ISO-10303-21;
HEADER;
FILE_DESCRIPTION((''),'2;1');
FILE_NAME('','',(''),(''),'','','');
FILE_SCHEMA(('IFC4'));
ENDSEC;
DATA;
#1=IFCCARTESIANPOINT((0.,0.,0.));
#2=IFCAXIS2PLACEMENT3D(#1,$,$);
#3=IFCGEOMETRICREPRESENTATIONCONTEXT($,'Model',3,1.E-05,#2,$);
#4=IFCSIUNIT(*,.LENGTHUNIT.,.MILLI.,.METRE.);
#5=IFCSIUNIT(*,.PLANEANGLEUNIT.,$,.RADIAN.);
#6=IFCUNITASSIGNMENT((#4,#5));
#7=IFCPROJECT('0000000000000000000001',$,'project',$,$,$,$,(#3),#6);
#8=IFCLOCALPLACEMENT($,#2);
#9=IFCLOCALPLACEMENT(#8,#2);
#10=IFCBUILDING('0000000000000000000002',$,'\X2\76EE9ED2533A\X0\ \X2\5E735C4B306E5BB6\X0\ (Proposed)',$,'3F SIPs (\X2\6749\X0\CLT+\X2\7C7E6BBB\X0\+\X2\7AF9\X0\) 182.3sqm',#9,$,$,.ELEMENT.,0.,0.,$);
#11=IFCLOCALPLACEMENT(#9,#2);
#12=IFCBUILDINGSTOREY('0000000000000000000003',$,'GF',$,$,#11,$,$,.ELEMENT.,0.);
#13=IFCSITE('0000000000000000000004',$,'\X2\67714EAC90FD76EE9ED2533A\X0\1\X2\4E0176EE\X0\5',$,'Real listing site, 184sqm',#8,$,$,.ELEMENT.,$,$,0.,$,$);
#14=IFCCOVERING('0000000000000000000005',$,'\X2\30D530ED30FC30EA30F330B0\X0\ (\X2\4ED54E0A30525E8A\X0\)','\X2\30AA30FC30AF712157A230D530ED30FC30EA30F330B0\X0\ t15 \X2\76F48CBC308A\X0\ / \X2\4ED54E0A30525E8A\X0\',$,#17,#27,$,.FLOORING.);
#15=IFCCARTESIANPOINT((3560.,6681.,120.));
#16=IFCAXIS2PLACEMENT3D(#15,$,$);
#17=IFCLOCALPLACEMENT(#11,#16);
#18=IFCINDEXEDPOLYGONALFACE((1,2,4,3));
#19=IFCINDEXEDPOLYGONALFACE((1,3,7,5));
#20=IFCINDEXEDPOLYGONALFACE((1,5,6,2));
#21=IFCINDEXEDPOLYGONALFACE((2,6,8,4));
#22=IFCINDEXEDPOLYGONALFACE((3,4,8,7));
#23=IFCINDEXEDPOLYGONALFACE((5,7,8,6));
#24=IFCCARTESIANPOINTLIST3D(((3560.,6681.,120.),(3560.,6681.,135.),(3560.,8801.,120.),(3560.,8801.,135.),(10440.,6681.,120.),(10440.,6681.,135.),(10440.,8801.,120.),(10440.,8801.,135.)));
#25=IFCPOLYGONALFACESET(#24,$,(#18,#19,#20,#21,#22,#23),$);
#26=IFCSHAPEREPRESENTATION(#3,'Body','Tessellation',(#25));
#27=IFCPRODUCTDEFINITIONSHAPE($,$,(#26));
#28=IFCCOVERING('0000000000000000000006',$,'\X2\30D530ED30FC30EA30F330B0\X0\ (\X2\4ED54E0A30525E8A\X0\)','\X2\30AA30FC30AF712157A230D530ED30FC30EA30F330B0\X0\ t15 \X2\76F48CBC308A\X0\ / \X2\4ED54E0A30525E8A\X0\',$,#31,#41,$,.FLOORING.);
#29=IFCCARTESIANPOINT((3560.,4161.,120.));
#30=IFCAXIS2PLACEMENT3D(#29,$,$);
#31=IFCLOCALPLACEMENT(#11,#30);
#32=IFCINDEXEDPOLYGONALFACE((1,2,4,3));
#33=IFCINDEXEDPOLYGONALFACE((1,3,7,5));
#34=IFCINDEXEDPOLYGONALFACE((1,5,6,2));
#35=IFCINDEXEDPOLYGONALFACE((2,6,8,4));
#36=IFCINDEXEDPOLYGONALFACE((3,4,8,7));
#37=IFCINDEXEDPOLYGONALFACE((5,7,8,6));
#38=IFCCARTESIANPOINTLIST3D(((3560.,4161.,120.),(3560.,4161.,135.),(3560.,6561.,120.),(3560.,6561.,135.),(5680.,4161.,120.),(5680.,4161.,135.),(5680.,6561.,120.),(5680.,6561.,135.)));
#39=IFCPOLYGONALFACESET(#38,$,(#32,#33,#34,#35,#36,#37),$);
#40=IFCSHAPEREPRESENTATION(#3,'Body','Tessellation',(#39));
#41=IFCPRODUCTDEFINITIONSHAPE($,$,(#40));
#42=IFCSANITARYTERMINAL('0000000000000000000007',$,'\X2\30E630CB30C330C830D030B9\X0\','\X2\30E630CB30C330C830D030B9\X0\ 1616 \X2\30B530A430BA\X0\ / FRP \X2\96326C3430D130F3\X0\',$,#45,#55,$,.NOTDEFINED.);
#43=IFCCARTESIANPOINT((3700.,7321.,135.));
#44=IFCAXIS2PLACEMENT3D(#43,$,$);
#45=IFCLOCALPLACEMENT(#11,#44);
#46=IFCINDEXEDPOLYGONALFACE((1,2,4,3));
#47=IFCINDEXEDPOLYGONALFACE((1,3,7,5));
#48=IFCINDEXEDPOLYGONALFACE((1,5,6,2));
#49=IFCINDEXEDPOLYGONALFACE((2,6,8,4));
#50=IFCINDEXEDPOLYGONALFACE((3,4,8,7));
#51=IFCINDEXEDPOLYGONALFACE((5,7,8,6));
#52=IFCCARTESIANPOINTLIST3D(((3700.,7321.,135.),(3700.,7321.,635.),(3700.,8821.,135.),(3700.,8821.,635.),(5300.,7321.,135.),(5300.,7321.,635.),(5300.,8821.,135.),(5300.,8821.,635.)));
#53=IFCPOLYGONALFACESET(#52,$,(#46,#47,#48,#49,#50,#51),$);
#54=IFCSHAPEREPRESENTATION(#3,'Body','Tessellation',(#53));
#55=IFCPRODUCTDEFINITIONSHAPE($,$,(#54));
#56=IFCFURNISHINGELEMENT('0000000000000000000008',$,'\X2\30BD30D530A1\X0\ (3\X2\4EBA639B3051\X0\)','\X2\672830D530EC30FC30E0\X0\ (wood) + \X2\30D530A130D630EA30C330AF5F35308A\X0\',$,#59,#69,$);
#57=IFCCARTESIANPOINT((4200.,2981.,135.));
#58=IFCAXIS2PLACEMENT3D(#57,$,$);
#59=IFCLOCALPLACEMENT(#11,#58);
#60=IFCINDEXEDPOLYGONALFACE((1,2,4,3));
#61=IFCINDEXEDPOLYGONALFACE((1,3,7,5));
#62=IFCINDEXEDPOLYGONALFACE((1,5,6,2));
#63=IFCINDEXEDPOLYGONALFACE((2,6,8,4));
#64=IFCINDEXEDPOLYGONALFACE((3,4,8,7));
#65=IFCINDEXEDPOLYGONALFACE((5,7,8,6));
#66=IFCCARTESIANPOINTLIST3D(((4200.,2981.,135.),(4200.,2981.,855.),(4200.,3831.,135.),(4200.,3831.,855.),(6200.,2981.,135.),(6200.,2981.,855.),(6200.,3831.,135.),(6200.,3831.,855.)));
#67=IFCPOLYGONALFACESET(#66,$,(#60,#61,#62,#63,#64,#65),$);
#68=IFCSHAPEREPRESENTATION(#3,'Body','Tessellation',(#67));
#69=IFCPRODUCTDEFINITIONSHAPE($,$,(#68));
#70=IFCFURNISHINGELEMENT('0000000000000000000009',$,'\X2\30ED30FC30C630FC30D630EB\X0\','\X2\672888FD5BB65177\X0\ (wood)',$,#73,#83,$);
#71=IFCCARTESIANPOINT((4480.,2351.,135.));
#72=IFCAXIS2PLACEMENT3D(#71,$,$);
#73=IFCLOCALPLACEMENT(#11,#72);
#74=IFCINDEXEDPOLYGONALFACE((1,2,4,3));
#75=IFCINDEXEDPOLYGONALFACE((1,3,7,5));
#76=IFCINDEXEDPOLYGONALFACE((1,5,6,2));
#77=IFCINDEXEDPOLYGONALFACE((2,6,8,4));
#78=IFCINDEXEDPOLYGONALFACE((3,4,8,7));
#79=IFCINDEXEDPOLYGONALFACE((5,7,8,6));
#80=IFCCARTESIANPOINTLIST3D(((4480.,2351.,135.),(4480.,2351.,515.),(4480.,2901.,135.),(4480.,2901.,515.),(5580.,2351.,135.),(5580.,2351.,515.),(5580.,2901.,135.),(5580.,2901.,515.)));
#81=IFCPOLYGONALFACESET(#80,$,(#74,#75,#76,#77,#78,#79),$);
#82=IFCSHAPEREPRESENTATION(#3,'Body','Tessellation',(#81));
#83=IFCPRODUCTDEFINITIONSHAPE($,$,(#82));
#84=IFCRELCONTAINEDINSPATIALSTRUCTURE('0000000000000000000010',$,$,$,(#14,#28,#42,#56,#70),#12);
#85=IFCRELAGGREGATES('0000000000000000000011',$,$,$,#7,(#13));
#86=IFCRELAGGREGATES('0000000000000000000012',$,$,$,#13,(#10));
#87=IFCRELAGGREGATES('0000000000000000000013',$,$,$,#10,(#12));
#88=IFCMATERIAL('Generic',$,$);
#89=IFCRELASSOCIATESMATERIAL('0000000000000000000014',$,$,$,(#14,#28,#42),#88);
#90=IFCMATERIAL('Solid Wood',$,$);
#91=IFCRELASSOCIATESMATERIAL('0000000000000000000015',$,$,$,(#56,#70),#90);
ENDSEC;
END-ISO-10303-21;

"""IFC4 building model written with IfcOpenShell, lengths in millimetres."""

from ifc_helpers import new_model, si_unit, frame, frame_2d, origin, place, context, project, spatial, rectangle, extrude, material, element, save


model = new_model("IFC4")

# Units and contexts
model_context = context("Model", 3, precision=1e-05, world=origin())
ifc_project = project(units=[si_unit("LENGTHUNIT", "METRE", prefix="MILLI"), si_unit("PLANEANGLEUNIT", "RADIAN")], contexts=[model_context])

# Site, building, storey
site_placement = place(None, origin())
site = spatial("IfcSite", under=ifc_project, at=site_placement, Name="東京都目黒区1丁目5", ObjectType="Real listing site, 184sqm", CompositionType="ELEMENT", RefElevation=0.0)
building_placement = place(site_placement, origin())
building = spatial("IfcBuilding", under=site, at=building_placement, Name="目黒区 平屋の家 (Proposed)", ObjectType="3F SIPs (杉CLT+籾殻+竹) 182.3sqm", CompositionType="ELEMENT", ElevationOfRefHeight=0.0, ElevationOfTerrain=0.0)
storey_placement = place(building_placement, origin())
storey = spatial("IfcBuildingStorey", under=building, at=storey_placement, Name="GF", CompositionType="ELEMENT", Elevation=0.0)

# Shared definitions
ifc_material_1 = material(Name="Solid Wood")

# Coverings
ifc_material_2 = material(Name="Generic")
covering_1_placement = place(storey_placement, frame((3560.0, 6681.0, 120.0)))
element("IfcCovering", 1, at=covering_1_placement, inside=storey, material=ifc_material_2, Name="フローリング (仕上げ床)", Description="オーク無垢フローリング t15 直貼り / 仕上げ床", PredefinedType="FLOORING", context=model_context, shape_type="SweptSolid", body=[
    extrude(rectangle(XDim=6880.0, YDim=2120.0, at=frame_2d((3440.0, 1060.0))), frame((3560.0, 6681.0, 120.0)), (0.0, 0.0, 1.0), 15.0),
])
covering_2_placement = place(storey_placement, frame((3560.0, 4161.0, 120.0)))
element("IfcCovering", 2, at=covering_2_placement, inside=storey, material=ifc_material_2, Name="フローリング (仕上げ床)", Description="オーク無垢フローリング t15 直貼り / 仕上げ床", PredefinedType="FLOORING", context=model_context, shape_type="SweptSolid", body=[
    extrude(rectangle(XDim=2120.0, YDim=2400.0, at=frame_2d((1060.0, 1200.0))), frame((3560.0, 4161.0, 120.0)), (0.0, 0.0, 1.0), 15.0),
])

# Sanitary terminal
sanitary_terminal_placement = place(storey_placement, frame((3700.0, 7321.0, 135.0)))
element("IfcSanitaryTerminal", 3, at=sanitary_terminal_placement, inside=storey, material=ifc_material_2, Name="ユニットバス", Description="ユニットバス 1616 サイズ / FRP 防水パン", PredefinedType="NOTDEFINED", context=model_context, shape_type="SweptSolid", body=[
    extrude(rectangle(XDim=1600.0, YDim=1500.0, at=frame_2d((800.0, 750.0))), frame((3700.0, 7321.0, 135.0)), (0.0, 0.0, 1.0), 500.0),
])

# Furnishing elements
furnishing_1_placement = place(storey_placement, frame((4200.0, 2981.0, 135.0)))
element("IfcFurnishingElement", 4, at=furnishing_1_placement, inside=storey, material=ifc_material_1, Name="ソファ (3人掛け)", Description="木フレーム (wood) + ファブリック張り", context=model_context, shape_type="SweptSolid", body=[
    extrude(rectangle(XDim=2000.0, YDim=850.0, at=frame_2d((1000.0, 425.0))), frame((4200.0, 2981.0, 135.0)), (0.0, 0.0, 1.0), 720.0),
])
furnishing_2_placement = place(storey_placement, frame((4480.0, 2351.0, 135.0)))
element("IfcFurnishingElement", 5, at=furnishing_2_placement, inside=storey, material=ifc_material_1, Name="ローテーブル", Description="木製家具 (wood)", context=model_context, shape_type="SweptSolid", body=[
    extrude(rectangle(XDim=1100.0, YDim=550.0, at=frame_2d((550.0, 275.0))), frame((4480.0, 2351.0, 135.0)), (0.0, 0.0, 1.0), 380.0),
])

save(model, "model.ifc")
